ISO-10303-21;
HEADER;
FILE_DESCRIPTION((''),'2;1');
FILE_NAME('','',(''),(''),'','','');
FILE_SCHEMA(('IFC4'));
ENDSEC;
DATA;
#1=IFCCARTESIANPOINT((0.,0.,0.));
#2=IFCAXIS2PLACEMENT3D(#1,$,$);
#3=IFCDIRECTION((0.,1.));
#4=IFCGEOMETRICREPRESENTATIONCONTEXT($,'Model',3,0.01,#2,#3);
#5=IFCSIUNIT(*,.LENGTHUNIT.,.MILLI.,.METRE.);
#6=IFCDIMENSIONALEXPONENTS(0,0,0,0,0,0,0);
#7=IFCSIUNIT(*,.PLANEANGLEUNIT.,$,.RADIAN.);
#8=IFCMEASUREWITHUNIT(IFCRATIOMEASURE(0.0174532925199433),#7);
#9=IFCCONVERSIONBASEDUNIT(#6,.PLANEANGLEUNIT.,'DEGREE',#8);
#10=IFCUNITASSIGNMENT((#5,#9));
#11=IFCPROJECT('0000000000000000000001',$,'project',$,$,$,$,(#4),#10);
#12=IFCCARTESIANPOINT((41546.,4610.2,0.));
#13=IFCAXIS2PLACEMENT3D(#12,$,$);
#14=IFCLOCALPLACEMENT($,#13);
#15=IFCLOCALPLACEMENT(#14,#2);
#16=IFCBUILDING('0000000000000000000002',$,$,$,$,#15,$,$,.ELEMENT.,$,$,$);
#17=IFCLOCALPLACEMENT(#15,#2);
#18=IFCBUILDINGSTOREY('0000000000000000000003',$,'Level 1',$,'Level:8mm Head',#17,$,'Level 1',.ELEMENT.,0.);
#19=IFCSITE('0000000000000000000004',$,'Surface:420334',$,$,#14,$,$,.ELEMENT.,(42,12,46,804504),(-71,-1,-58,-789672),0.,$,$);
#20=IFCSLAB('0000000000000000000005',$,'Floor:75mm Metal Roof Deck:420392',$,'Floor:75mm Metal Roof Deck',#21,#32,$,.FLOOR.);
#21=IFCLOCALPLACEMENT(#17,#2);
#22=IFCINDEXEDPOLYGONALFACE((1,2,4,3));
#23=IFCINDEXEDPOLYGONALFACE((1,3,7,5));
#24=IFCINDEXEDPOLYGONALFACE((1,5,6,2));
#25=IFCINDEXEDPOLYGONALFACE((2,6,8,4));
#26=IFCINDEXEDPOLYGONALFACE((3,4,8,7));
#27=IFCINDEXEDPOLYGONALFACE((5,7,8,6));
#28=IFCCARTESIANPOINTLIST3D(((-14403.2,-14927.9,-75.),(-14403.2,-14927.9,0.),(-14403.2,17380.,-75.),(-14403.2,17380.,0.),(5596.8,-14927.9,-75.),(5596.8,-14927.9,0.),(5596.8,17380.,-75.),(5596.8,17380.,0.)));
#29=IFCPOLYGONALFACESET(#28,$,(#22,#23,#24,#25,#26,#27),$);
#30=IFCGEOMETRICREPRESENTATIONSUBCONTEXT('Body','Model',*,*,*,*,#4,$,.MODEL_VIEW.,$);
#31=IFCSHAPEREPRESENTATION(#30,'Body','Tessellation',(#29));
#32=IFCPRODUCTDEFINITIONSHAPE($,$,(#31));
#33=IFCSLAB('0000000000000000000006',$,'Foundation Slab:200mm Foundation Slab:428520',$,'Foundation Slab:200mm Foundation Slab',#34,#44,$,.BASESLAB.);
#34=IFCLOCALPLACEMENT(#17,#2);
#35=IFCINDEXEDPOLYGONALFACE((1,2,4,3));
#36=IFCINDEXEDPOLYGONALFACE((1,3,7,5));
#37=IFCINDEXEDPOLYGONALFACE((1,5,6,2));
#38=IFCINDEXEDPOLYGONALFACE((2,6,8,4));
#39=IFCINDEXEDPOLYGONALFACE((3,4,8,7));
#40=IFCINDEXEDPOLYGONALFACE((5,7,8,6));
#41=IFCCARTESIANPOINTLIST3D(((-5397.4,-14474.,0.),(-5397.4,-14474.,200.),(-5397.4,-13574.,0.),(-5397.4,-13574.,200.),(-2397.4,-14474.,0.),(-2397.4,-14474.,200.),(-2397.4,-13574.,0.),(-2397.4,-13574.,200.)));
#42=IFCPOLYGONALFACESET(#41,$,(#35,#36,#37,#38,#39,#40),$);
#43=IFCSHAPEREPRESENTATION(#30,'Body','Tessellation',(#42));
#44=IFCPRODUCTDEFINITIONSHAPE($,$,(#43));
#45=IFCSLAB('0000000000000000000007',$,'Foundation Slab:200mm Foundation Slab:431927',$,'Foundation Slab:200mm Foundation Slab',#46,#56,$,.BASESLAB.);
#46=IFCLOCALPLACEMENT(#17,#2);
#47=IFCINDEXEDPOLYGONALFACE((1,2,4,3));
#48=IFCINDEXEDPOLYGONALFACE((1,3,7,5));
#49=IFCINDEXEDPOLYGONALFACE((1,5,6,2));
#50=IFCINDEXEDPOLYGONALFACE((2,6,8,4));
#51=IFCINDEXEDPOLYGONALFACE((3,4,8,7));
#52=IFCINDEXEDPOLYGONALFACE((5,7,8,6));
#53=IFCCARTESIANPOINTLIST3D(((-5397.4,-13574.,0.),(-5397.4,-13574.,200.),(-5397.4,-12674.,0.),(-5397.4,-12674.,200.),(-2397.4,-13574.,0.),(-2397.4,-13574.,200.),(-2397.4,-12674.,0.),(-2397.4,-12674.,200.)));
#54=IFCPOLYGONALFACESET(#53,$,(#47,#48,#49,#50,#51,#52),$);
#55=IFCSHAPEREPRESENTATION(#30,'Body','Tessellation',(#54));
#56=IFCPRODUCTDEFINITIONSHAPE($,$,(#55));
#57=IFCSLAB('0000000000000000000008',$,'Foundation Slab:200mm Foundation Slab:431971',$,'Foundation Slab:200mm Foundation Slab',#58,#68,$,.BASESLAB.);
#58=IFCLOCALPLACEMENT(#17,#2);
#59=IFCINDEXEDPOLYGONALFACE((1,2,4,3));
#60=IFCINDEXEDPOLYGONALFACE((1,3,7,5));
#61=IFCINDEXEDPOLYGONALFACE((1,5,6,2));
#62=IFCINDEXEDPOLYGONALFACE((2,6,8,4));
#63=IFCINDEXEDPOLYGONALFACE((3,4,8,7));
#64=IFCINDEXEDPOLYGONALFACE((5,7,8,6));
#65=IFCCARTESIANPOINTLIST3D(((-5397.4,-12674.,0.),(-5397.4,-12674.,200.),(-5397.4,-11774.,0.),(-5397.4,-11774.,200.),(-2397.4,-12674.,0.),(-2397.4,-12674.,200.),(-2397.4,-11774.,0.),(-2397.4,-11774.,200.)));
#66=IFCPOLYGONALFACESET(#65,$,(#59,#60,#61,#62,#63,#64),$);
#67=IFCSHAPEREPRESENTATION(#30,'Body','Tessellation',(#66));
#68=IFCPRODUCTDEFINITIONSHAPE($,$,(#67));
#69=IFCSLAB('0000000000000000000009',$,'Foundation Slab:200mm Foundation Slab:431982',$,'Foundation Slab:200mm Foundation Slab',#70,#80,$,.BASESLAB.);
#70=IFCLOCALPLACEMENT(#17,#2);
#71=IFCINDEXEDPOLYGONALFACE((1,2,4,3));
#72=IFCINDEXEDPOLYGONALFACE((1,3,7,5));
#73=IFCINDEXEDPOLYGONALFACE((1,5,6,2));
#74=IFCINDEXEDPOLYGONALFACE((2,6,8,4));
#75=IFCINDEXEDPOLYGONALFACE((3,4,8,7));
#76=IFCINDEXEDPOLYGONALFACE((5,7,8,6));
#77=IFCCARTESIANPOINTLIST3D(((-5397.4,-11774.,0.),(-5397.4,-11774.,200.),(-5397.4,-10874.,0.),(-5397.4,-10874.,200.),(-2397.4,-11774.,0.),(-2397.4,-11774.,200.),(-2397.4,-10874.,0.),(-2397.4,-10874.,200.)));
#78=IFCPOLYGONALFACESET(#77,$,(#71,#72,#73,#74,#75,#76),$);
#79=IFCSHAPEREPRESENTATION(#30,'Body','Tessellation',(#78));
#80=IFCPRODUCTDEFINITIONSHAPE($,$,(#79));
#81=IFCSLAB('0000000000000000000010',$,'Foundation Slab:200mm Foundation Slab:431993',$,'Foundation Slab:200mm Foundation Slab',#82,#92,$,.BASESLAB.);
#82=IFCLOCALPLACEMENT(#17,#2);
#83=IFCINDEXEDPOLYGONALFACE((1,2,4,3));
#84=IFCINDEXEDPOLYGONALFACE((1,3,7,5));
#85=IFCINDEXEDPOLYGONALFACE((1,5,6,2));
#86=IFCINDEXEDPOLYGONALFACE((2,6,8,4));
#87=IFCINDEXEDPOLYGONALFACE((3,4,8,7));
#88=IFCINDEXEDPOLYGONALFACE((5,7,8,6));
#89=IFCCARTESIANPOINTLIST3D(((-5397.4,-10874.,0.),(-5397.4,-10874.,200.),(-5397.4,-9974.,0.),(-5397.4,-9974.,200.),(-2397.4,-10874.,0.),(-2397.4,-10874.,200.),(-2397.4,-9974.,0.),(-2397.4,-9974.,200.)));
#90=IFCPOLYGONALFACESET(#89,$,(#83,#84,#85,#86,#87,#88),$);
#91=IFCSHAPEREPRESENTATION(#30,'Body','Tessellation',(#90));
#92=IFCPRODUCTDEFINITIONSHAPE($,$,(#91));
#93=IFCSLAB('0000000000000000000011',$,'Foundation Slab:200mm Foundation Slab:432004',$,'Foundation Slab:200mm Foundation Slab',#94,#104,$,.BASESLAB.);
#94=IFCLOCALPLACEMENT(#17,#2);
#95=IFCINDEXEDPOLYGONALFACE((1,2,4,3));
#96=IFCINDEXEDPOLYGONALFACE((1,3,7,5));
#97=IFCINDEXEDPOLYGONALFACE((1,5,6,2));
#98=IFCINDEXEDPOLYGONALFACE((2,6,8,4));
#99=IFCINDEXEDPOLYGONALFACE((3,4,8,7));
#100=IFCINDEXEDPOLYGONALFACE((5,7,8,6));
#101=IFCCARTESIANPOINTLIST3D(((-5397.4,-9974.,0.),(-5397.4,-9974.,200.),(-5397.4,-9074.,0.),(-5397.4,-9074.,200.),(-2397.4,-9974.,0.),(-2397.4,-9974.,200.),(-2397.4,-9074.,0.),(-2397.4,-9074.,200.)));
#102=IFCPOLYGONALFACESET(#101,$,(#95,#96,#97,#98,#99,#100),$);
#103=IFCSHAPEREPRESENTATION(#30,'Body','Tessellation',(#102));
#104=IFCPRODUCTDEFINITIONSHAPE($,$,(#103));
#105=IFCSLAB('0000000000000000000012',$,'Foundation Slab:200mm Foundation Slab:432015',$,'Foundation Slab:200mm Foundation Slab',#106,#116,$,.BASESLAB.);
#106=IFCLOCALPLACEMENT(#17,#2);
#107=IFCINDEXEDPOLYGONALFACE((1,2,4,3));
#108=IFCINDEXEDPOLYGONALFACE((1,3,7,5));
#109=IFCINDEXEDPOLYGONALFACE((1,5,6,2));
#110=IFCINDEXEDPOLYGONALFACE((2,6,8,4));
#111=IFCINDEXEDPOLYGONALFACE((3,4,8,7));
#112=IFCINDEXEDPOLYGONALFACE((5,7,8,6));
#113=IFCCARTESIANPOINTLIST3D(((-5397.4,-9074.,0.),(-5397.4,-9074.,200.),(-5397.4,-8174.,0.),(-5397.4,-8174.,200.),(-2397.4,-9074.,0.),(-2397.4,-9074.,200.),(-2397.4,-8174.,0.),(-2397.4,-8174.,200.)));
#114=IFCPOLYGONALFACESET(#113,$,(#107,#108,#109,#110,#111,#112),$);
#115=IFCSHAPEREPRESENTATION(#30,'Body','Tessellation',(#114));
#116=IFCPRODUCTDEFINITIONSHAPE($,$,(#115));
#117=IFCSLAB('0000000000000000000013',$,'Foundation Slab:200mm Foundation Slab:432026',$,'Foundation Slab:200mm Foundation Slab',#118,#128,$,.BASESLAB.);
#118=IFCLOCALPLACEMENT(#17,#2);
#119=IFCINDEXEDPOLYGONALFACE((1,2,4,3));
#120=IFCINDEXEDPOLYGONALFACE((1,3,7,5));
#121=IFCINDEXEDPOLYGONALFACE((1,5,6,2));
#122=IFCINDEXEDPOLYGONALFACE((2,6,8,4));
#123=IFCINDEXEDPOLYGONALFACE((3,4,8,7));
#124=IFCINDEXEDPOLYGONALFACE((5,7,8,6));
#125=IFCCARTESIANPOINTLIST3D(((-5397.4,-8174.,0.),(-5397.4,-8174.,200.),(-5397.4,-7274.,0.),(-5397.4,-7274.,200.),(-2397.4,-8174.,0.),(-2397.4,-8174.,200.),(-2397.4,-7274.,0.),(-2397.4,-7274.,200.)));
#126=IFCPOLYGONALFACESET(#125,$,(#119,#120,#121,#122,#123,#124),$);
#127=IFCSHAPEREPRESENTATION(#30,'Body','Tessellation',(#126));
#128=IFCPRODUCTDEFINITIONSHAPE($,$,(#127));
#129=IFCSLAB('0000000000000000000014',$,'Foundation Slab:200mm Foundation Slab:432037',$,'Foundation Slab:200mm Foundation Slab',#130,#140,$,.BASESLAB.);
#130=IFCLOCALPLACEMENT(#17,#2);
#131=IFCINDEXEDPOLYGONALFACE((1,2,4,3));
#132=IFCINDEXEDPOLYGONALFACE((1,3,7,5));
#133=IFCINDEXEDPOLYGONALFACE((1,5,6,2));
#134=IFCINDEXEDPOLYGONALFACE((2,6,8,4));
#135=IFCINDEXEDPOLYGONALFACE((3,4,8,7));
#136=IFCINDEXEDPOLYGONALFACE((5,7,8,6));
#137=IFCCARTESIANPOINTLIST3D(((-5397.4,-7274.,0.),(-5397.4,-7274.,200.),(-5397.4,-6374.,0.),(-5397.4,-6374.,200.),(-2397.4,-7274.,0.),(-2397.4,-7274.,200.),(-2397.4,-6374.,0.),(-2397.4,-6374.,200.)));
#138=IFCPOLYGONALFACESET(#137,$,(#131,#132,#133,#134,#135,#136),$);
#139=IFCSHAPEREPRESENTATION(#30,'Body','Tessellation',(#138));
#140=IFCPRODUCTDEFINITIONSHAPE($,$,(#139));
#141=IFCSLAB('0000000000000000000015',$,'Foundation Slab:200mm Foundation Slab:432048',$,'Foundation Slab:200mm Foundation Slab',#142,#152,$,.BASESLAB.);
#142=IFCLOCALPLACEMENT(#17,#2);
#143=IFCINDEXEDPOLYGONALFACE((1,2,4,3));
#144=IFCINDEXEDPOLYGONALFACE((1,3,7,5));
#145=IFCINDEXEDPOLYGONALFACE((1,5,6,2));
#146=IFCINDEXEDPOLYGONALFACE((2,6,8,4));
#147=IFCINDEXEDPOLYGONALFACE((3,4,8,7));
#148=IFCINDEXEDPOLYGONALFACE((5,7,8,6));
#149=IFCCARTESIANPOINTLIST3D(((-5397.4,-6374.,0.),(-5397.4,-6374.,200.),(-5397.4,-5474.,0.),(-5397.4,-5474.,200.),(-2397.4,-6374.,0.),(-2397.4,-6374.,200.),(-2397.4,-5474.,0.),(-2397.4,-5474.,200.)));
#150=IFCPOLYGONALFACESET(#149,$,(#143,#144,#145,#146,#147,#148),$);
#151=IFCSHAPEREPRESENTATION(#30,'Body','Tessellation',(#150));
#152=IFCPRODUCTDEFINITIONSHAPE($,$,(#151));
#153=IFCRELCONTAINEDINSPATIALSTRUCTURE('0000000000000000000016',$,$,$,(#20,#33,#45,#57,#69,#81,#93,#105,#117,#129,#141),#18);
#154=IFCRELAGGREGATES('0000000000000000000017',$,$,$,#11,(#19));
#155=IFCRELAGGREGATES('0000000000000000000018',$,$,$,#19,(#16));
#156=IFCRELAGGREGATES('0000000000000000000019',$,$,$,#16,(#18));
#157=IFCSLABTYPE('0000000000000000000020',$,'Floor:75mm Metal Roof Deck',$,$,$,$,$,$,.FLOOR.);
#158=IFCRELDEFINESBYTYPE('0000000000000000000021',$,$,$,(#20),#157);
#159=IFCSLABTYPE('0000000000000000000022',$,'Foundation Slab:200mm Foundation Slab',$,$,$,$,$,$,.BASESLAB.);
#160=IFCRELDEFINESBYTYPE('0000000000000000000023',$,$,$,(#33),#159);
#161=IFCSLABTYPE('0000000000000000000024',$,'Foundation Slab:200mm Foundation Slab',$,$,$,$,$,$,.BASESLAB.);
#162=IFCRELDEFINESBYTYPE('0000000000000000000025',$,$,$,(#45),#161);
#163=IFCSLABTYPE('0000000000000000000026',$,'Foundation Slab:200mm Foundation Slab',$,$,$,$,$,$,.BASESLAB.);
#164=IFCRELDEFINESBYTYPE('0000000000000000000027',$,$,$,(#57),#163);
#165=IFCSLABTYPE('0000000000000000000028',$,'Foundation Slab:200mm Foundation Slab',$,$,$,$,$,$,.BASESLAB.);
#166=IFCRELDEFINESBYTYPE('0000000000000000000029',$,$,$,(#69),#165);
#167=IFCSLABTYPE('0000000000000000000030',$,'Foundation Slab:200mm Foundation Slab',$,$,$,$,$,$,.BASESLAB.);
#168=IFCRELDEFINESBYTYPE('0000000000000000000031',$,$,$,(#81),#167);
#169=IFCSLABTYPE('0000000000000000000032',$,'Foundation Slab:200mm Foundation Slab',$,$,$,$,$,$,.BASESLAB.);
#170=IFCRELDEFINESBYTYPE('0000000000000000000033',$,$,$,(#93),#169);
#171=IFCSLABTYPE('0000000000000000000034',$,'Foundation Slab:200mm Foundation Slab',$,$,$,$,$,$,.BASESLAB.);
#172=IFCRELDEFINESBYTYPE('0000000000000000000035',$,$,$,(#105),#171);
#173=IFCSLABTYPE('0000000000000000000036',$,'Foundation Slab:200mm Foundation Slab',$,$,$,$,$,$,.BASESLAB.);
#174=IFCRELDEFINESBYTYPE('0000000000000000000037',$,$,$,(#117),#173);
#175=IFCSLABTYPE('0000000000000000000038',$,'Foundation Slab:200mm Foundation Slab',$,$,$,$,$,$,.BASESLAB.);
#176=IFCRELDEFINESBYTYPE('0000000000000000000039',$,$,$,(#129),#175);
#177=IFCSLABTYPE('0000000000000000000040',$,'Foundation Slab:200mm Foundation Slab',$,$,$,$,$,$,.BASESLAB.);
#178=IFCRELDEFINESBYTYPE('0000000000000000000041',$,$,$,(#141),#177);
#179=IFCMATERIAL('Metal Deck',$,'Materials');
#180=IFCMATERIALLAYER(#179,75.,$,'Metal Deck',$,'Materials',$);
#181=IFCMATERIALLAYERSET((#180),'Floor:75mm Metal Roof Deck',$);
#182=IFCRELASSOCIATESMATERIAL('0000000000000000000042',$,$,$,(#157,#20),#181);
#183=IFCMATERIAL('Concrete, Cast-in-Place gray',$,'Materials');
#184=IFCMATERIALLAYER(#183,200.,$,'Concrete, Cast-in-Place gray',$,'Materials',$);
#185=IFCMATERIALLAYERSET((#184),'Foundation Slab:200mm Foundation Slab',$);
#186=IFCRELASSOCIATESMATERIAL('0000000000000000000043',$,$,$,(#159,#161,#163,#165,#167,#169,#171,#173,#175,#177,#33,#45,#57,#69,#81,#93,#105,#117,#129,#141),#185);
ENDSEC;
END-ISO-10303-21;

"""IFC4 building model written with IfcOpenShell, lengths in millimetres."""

from ifc_helpers import new_model, entity, si_unit, converted_unit, direction, frame, frame_2d, origin, origin_2d_with_axis, place, context, subcontext, project, spatial, rectangle, extrude, material, layer, layer_set, layer_usage, type_object, element, save


model = new_model("IFC4")

# Units and contexts
model_context = context("Model", 3, precision=0.01, world=origin(), true_north=direction((0.0, 1.0)))
body_context = subcontext(model_context, "Body", "Model", "MODEL_VIEW")
ifc_project = project(units=[si_unit("LENGTHUNIT", "METRE", prefix="MILLI"), converted_unit("PLANEANGLEUNIT", "DEGREE", entity("IfcRatioMeasure", 0.0174532925199433), si_unit("PLANEANGLEUNIT", "RADIAN"), dimensions=[0, 0, 0, 0, 0, 0, 0])], contexts=[model_context])

# Site, building, storey
site_placement = place(None, frame((41546.0, 4610.2, 0.0)))
site = spatial("IfcSite", under=ifc_project, at=site_placement, Name="Surface:420334", CompositionType="ELEMENT", RefLatitude=(42, 12, 46, 804504), RefLongitude=(-71, -1, -58, -789672), RefElevation=0.0)
building_placement = place(site_placement, origin())
building = spatial("IfcBuilding", under=site, at=building_placement, CompositionType="ELEMENT")
storey_placement = place(building_placement, origin())
storey = spatial("IfcBuildingStorey", under=building, at=storey_placement, Name="Level 1", ObjectType="Level:8mm Head", LongName="Level 1", CompositionType="ELEMENT", Elevation=0.0)

# Slabs
ifc_material_1 = material(Name="Metal Deck", Category="Materials")
ifc_layer_1 = layer(ifc_material_1, 75.0, Name="Metal Deck", Category="Materials")
ifc_layer_set_1 = layer_set([ifc_layer_1], Name="Floor:75mm Metal Roof Deck")
ifc_layer_usage_1 = layer_usage(ifc_layer_set_1, "AXIS3", "POSITIVE", 0.0)
slab_type_1 = type_object("IfcSlabType", Name="Floor:75mm Metal Roof Deck", PredefinedType="FLOOR", material=ifc_layer_set_1)
slab_1_placement = place(storey_placement, origin())
element("IfcSlab", 1, at=slab_1_placement, inside=storey, type_object=slab_type_1, material=ifc_layer_usage_1, Name="Floor:75mm Metal Roof Deck:420392", ObjectType="Floor:75mm Metal Roof Deck", PredefinedType="FLOOR", context=body_context, shape_type="SweptSolid", body=[
    extrude(rectangle(XDim=32307.9, YDim=20000.0, at=frame_2d((0.0, 0.0), x_axis=(1.0, 0.0))), frame((-4403.2, 1226.0, 0.0), z_axis=(0.0, 0.0, -1.0), x_axis=(0.0, 1.0, 0.0)), (0.0, 0.0, 1.0), 75.0),
])
ifc_material_2 = material(Name="Concrete, Cast-in-Place gray", Category="Materials")
ifc_layer_2 = layer(ifc_material_2, 200.0, Name="Concrete, Cast-in-Place gray", Category="Materials")
ifc_layer_set_2 = layer_set([ifc_layer_2], Name="Foundation Slab:200mm Foundation Slab")
ifc_layer_usage_2 = layer_usage(ifc_layer_set_2, "AXIS3", "POSITIVE", 0.0)
slab_type_2 = type_object("IfcSlabType", Name="Foundation Slab:200mm Foundation Slab", PredefinedType="BASESLAB", material=ifc_layer_set_2)
slab_2_placement = place(storey_placement, origin())
element("IfcSlab", 2, at=slab_2_placement, inside=storey, type_object=slab_type_2, material=ifc_layer_usage_2, Name="Foundation Slab:200mm Foundation Slab:428520", ObjectType="Foundation Slab:200mm Foundation Slab", PredefinedType="BASESLAB", context=body_context, shape_type="SweptSolid", body=[
    extrude(rectangle(XDim=900.0, YDim=3000.0, at=frame_2d((0.0, 0.0), x_axis=(1.0, 0.0))), frame((-3897.4, -14024.0, 200.0), z_axis=(0.0, 0.0, -1.0), x_axis=(0.0, 1.0, 0.0)), (0.0, 0.0, 1.0), 200.0),
])
ifc_layer_usage_3 = layer_usage(ifc_layer_set_2, "AXIS3", "POSITIVE", 0.0)
slab_type_3 = type_object("IfcSlabType", Name="Foundation Slab:200mm Foundation Slab", PredefinedType="BASESLAB", material=ifc_layer_set_2)
slab_3_placement = place(storey_placement, origin())
element("IfcSlab", 3, at=slab_3_placement, inside=storey, type_object=slab_type_3, material=ifc_layer_usage_3, Name="Foundation Slab:200mm Foundation Slab:431927", ObjectType="Foundation Slab:200mm Foundation Slab", PredefinedType="BASESLAB", context=body_context, shape_type="SweptSolid", body=[
    extrude(rectangle(XDim=900.0, YDim=3000.0, at=frame_2d((0.0, 0.0), x_axis=(1.0, 0.0))), frame((-3897.4, -13124.0, 200.0), z_axis=(0.0, 0.0, -1.0), x_axis=(0.0, 1.0, 0.0)), (0.0, 0.0, 1.0), 200.0),
])
ifc_layer_usage_4 = layer_usage(ifc_layer_set_2, "AXIS3", "POSITIVE", 0.0)
slab_type_4 = type_object("IfcSlabType", Name="Foundation Slab:200mm Foundation Slab", PredefinedType="BASESLAB", material=ifc_layer_set_2)
slab_4_placement = place(storey_placement, origin())
element("IfcSlab", 4, at=slab_4_placement, inside=storey, type_object=slab_type_4, material=ifc_layer_usage_4, Name="Foundation Slab:200mm Foundation Slab:431971", ObjectType="Foundation Slab:200mm Foundation Slab", PredefinedType="BASESLAB", context=body_context, shape_type="SweptSolid", body=[
    extrude(rectangle(XDim=900.0, YDim=3000.0, at=origin_2d_with_axis()), frame((-3897.4, -12224.0, 200.0), z_axis=(0.0, 0.0, -1.0), x_axis=(0.0, 1.0, 0.0)), (0.0, 0.0, 1.0), 200.0),
])
ifc_layer_usage_5 = layer_usage(ifc_layer_set_2, "AXIS3", "POSITIVE", 0.0)
slab_type_5 = type_object("IfcSlabType", Name="Foundation Slab:200mm Foundation Slab", PredefinedType="BASESLAB", material=ifc_layer_set_2)
slab_5_placement = place(storey_placement, origin())
element("IfcSlab", 5, at=slab_5_placement, inside=storey, type_object=slab_type_5, material=ifc_layer_usage_5, Name="Foundation Slab:200mm Foundation Slab:431982", ObjectType="Foundation Slab:200mm Foundation Slab", PredefinedType="BASESLAB", context=body_context, shape_type="SweptSolid", body=[
    extrude(rectangle(XDim=900.0, YDim=3000.0, at=origin_2d_with_axis()), frame((-3897.4, -11324.0, 200.0), z_axis=(0.0, 0.0, -1.0), x_axis=(0.0, 1.0, 0.0)), (0.0, 0.0, 1.0), 200.0),
])
ifc_layer_usage_6 = layer_usage(ifc_layer_set_2, "AXIS3", "POSITIVE", 0.0)
slab_type_6 = type_object("IfcSlabType", Name="Foundation Slab:200mm Foundation Slab", PredefinedType="BASESLAB", material=ifc_layer_set_2)
slab_6_placement = place(storey_placement, origin())
element("IfcSlab", 6, at=slab_6_placement, inside=storey, type_object=slab_type_6, material=ifc_layer_usage_6, Name="Foundation Slab:200mm Foundation Slab:431993", ObjectType="Foundation Slab:200mm Foundation Slab", PredefinedType="BASESLAB", context=body_context, shape_type="SweptSolid", body=[
    extrude(rectangle(XDim=900.0, YDim=3000.0, at=origin_2d_with_axis()), frame((-3897.4, -10424.0, 200.0), z_axis=(0.0, 0.0, -1.0), x_axis=(0.0, 1.0, 0.0)), (0.0, 0.0, 1.0), 200.0),
])
ifc_layer_usage_7 = layer_usage(ifc_layer_set_2, "AXIS3", "POSITIVE", 0.0)
slab_type_7 = type_object("IfcSlabType", Name="Foundation Slab:200mm Foundation Slab", PredefinedType="BASESLAB", material=ifc_layer_set_2)
slab_7_placement = place(storey_placement, origin())
element("IfcSlab", 7, at=slab_7_placement, inside=storey, type_object=slab_type_7, material=ifc_layer_usage_7, Name="Foundation Slab:200mm Foundation Slab:432004", ObjectType="Foundation Slab:200mm Foundation Slab", PredefinedType="BASESLAB", context=body_context, shape_type="SweptSolid", body=[
    extrude(rectangle(XDim=900.0, YDim=3000.0, at=origin_2d_with_axis()), frame((-3897.4, -9524.0, 200.0), z_axis=(0.0, 0.0, -1.0), x_axis=(0.0, 1.0, 0.0)), (0.0, 0.0, 1.0), 200.0),
])
ifc_layer_usage_8 = layer_usage(ifc_layer_set_2, "AXIS3", "POSITIVE", 0.0)
slab_type_8 = type_object("IfcSlabType", Name="Foundation Slab:200mm Foundation Slab", PredefinedType="BASESLAB", material=ifc_layer_set_2)
slab_8_placement = place(storey_placement, origin())
element("IfcSlab", 8, at=slab_8_placement, inside=storey, type_object=slab_type_8, material=ifc_layer_usage_8, Name="Foundation Slab:200mm Foundation Slab:432015", ObjectType="Foundation Slab:200mm Foundation Slab", PredefinedType="BASESLAB", context=body_context, shape_type="SweptSolid", body=[
    extrude(rectangle(XDim=900.0, YDim=3000.0, at=origin_2d_with_axis()), frame((-3897.4, -8624.0, 200.0), z_axis=(0.0, 0.0, -1.0), x_axis=(0.0, 1.0, 0.0)), (0.0, 0.0, 1.0), 200.0),
])
ifc_layer_usage_9 = layer_usage(ifc_layer_set_2, "AXIS3", "POSITIVE", 0.0)
slab_type_9 = type_object("IfcSlabType", Name="Foundation Slab:200mm Foundation Slab", PredefinedType="BASESLAB", material=ifc_layer_set_2)
slab_9_placement = place(storey_placement, origin())
element("IfcSlab", 9, at=slab_9_placement, inside=storey, type_object=slab_type_9, material=ifc_layer_usage_9, Name="Foundation Slab:200mm Foundation Slab:432026", ObjectType="Foundation Slab:200mm Foundation Slab", PredefinedType="BASESLAB", context=body_context, shape_type="SweptSolid", body=[
    extrude(rectangle(XDim=900.0, YDim=3000.0, at=origin_2d_with_axis()), frame((-3897.4, -7724.0, 200.0), z_axis=(0.0, 0.0, -1.0), x_axis=(0.0, 1.0, 0.0)), (0.0, 0.0, 1.0), 200.0),
])
ifc_layer_usage_10 = layer_usage(ifc_layer_set_2, "AXIS3", "POSITIVE", 0.0)
slab_type_10 = type_object("IfcSlabType", Name="Foundation Slab:200mm Foundation Slab", PredefinedType="BASESLAB", material=ifc_layer_set_2)
slab_10_placement = place(storey_placement, origin())
element("IfcSlab", 10, at=slab_10_placement, inside=storey, type_object=slab_type_10, material=ifc_layer_usage_10, Name="Foundation Slab:200mm Foundation Slab:432037", ObjectType="Foundation Slab:200mm Foundation Slab", PredefinedType="BASESLAB", context=body_context, shape_type="SweptSolid", body=[
    extrude(rectangle(XDim=900.0, YDim=3000.0, at=origin_2d_with_axis()), frame((-3897.4, -6824.0, 200.0), z_axis=(0.0, 0.0, -1.0), x_axis=(0.0, 1.0, 0.0)), (0.0, 0.0, 1.0), 200.0),
])
ifc_layer_usage_11 = layer_usage(ifc_layer_set_2, "AXIS3", "POSITIVE", 0.0)
slab_type_11 = type_object("IfcSlabType", Name="Foundation Slab:200mm Foundation Slab", PredefinedType="BASESLAB", material=ifc_layer_set_2)
slab_11_placement = place(storey_placement, origin())
element("IfcSlab", 11, at=slab_11_placement, inside=storey, type_object=slab_type_11, material=ifc_layer_usage_11, Name="Foundation Slab:200mm Foundation Slab:432048", ObjectType="Foundation Slab:200mm Foundation Slab", PredefinedType="BASESLAB", context=body_context, shape_type="SweptSolid", body=[
    extrude(rectangle(XDim=900.0, YDim=3000.0, at=origin_2d_with_axis()), frame((-3897.4, -5924.0, 200.0), z_axis=(0.0, 0.0, -1.0), x_axis=(0.0, 1.0, 0.0)), (0.0, 0.0, 1.0), 200.0),
])

save(model, "model.ifc")
